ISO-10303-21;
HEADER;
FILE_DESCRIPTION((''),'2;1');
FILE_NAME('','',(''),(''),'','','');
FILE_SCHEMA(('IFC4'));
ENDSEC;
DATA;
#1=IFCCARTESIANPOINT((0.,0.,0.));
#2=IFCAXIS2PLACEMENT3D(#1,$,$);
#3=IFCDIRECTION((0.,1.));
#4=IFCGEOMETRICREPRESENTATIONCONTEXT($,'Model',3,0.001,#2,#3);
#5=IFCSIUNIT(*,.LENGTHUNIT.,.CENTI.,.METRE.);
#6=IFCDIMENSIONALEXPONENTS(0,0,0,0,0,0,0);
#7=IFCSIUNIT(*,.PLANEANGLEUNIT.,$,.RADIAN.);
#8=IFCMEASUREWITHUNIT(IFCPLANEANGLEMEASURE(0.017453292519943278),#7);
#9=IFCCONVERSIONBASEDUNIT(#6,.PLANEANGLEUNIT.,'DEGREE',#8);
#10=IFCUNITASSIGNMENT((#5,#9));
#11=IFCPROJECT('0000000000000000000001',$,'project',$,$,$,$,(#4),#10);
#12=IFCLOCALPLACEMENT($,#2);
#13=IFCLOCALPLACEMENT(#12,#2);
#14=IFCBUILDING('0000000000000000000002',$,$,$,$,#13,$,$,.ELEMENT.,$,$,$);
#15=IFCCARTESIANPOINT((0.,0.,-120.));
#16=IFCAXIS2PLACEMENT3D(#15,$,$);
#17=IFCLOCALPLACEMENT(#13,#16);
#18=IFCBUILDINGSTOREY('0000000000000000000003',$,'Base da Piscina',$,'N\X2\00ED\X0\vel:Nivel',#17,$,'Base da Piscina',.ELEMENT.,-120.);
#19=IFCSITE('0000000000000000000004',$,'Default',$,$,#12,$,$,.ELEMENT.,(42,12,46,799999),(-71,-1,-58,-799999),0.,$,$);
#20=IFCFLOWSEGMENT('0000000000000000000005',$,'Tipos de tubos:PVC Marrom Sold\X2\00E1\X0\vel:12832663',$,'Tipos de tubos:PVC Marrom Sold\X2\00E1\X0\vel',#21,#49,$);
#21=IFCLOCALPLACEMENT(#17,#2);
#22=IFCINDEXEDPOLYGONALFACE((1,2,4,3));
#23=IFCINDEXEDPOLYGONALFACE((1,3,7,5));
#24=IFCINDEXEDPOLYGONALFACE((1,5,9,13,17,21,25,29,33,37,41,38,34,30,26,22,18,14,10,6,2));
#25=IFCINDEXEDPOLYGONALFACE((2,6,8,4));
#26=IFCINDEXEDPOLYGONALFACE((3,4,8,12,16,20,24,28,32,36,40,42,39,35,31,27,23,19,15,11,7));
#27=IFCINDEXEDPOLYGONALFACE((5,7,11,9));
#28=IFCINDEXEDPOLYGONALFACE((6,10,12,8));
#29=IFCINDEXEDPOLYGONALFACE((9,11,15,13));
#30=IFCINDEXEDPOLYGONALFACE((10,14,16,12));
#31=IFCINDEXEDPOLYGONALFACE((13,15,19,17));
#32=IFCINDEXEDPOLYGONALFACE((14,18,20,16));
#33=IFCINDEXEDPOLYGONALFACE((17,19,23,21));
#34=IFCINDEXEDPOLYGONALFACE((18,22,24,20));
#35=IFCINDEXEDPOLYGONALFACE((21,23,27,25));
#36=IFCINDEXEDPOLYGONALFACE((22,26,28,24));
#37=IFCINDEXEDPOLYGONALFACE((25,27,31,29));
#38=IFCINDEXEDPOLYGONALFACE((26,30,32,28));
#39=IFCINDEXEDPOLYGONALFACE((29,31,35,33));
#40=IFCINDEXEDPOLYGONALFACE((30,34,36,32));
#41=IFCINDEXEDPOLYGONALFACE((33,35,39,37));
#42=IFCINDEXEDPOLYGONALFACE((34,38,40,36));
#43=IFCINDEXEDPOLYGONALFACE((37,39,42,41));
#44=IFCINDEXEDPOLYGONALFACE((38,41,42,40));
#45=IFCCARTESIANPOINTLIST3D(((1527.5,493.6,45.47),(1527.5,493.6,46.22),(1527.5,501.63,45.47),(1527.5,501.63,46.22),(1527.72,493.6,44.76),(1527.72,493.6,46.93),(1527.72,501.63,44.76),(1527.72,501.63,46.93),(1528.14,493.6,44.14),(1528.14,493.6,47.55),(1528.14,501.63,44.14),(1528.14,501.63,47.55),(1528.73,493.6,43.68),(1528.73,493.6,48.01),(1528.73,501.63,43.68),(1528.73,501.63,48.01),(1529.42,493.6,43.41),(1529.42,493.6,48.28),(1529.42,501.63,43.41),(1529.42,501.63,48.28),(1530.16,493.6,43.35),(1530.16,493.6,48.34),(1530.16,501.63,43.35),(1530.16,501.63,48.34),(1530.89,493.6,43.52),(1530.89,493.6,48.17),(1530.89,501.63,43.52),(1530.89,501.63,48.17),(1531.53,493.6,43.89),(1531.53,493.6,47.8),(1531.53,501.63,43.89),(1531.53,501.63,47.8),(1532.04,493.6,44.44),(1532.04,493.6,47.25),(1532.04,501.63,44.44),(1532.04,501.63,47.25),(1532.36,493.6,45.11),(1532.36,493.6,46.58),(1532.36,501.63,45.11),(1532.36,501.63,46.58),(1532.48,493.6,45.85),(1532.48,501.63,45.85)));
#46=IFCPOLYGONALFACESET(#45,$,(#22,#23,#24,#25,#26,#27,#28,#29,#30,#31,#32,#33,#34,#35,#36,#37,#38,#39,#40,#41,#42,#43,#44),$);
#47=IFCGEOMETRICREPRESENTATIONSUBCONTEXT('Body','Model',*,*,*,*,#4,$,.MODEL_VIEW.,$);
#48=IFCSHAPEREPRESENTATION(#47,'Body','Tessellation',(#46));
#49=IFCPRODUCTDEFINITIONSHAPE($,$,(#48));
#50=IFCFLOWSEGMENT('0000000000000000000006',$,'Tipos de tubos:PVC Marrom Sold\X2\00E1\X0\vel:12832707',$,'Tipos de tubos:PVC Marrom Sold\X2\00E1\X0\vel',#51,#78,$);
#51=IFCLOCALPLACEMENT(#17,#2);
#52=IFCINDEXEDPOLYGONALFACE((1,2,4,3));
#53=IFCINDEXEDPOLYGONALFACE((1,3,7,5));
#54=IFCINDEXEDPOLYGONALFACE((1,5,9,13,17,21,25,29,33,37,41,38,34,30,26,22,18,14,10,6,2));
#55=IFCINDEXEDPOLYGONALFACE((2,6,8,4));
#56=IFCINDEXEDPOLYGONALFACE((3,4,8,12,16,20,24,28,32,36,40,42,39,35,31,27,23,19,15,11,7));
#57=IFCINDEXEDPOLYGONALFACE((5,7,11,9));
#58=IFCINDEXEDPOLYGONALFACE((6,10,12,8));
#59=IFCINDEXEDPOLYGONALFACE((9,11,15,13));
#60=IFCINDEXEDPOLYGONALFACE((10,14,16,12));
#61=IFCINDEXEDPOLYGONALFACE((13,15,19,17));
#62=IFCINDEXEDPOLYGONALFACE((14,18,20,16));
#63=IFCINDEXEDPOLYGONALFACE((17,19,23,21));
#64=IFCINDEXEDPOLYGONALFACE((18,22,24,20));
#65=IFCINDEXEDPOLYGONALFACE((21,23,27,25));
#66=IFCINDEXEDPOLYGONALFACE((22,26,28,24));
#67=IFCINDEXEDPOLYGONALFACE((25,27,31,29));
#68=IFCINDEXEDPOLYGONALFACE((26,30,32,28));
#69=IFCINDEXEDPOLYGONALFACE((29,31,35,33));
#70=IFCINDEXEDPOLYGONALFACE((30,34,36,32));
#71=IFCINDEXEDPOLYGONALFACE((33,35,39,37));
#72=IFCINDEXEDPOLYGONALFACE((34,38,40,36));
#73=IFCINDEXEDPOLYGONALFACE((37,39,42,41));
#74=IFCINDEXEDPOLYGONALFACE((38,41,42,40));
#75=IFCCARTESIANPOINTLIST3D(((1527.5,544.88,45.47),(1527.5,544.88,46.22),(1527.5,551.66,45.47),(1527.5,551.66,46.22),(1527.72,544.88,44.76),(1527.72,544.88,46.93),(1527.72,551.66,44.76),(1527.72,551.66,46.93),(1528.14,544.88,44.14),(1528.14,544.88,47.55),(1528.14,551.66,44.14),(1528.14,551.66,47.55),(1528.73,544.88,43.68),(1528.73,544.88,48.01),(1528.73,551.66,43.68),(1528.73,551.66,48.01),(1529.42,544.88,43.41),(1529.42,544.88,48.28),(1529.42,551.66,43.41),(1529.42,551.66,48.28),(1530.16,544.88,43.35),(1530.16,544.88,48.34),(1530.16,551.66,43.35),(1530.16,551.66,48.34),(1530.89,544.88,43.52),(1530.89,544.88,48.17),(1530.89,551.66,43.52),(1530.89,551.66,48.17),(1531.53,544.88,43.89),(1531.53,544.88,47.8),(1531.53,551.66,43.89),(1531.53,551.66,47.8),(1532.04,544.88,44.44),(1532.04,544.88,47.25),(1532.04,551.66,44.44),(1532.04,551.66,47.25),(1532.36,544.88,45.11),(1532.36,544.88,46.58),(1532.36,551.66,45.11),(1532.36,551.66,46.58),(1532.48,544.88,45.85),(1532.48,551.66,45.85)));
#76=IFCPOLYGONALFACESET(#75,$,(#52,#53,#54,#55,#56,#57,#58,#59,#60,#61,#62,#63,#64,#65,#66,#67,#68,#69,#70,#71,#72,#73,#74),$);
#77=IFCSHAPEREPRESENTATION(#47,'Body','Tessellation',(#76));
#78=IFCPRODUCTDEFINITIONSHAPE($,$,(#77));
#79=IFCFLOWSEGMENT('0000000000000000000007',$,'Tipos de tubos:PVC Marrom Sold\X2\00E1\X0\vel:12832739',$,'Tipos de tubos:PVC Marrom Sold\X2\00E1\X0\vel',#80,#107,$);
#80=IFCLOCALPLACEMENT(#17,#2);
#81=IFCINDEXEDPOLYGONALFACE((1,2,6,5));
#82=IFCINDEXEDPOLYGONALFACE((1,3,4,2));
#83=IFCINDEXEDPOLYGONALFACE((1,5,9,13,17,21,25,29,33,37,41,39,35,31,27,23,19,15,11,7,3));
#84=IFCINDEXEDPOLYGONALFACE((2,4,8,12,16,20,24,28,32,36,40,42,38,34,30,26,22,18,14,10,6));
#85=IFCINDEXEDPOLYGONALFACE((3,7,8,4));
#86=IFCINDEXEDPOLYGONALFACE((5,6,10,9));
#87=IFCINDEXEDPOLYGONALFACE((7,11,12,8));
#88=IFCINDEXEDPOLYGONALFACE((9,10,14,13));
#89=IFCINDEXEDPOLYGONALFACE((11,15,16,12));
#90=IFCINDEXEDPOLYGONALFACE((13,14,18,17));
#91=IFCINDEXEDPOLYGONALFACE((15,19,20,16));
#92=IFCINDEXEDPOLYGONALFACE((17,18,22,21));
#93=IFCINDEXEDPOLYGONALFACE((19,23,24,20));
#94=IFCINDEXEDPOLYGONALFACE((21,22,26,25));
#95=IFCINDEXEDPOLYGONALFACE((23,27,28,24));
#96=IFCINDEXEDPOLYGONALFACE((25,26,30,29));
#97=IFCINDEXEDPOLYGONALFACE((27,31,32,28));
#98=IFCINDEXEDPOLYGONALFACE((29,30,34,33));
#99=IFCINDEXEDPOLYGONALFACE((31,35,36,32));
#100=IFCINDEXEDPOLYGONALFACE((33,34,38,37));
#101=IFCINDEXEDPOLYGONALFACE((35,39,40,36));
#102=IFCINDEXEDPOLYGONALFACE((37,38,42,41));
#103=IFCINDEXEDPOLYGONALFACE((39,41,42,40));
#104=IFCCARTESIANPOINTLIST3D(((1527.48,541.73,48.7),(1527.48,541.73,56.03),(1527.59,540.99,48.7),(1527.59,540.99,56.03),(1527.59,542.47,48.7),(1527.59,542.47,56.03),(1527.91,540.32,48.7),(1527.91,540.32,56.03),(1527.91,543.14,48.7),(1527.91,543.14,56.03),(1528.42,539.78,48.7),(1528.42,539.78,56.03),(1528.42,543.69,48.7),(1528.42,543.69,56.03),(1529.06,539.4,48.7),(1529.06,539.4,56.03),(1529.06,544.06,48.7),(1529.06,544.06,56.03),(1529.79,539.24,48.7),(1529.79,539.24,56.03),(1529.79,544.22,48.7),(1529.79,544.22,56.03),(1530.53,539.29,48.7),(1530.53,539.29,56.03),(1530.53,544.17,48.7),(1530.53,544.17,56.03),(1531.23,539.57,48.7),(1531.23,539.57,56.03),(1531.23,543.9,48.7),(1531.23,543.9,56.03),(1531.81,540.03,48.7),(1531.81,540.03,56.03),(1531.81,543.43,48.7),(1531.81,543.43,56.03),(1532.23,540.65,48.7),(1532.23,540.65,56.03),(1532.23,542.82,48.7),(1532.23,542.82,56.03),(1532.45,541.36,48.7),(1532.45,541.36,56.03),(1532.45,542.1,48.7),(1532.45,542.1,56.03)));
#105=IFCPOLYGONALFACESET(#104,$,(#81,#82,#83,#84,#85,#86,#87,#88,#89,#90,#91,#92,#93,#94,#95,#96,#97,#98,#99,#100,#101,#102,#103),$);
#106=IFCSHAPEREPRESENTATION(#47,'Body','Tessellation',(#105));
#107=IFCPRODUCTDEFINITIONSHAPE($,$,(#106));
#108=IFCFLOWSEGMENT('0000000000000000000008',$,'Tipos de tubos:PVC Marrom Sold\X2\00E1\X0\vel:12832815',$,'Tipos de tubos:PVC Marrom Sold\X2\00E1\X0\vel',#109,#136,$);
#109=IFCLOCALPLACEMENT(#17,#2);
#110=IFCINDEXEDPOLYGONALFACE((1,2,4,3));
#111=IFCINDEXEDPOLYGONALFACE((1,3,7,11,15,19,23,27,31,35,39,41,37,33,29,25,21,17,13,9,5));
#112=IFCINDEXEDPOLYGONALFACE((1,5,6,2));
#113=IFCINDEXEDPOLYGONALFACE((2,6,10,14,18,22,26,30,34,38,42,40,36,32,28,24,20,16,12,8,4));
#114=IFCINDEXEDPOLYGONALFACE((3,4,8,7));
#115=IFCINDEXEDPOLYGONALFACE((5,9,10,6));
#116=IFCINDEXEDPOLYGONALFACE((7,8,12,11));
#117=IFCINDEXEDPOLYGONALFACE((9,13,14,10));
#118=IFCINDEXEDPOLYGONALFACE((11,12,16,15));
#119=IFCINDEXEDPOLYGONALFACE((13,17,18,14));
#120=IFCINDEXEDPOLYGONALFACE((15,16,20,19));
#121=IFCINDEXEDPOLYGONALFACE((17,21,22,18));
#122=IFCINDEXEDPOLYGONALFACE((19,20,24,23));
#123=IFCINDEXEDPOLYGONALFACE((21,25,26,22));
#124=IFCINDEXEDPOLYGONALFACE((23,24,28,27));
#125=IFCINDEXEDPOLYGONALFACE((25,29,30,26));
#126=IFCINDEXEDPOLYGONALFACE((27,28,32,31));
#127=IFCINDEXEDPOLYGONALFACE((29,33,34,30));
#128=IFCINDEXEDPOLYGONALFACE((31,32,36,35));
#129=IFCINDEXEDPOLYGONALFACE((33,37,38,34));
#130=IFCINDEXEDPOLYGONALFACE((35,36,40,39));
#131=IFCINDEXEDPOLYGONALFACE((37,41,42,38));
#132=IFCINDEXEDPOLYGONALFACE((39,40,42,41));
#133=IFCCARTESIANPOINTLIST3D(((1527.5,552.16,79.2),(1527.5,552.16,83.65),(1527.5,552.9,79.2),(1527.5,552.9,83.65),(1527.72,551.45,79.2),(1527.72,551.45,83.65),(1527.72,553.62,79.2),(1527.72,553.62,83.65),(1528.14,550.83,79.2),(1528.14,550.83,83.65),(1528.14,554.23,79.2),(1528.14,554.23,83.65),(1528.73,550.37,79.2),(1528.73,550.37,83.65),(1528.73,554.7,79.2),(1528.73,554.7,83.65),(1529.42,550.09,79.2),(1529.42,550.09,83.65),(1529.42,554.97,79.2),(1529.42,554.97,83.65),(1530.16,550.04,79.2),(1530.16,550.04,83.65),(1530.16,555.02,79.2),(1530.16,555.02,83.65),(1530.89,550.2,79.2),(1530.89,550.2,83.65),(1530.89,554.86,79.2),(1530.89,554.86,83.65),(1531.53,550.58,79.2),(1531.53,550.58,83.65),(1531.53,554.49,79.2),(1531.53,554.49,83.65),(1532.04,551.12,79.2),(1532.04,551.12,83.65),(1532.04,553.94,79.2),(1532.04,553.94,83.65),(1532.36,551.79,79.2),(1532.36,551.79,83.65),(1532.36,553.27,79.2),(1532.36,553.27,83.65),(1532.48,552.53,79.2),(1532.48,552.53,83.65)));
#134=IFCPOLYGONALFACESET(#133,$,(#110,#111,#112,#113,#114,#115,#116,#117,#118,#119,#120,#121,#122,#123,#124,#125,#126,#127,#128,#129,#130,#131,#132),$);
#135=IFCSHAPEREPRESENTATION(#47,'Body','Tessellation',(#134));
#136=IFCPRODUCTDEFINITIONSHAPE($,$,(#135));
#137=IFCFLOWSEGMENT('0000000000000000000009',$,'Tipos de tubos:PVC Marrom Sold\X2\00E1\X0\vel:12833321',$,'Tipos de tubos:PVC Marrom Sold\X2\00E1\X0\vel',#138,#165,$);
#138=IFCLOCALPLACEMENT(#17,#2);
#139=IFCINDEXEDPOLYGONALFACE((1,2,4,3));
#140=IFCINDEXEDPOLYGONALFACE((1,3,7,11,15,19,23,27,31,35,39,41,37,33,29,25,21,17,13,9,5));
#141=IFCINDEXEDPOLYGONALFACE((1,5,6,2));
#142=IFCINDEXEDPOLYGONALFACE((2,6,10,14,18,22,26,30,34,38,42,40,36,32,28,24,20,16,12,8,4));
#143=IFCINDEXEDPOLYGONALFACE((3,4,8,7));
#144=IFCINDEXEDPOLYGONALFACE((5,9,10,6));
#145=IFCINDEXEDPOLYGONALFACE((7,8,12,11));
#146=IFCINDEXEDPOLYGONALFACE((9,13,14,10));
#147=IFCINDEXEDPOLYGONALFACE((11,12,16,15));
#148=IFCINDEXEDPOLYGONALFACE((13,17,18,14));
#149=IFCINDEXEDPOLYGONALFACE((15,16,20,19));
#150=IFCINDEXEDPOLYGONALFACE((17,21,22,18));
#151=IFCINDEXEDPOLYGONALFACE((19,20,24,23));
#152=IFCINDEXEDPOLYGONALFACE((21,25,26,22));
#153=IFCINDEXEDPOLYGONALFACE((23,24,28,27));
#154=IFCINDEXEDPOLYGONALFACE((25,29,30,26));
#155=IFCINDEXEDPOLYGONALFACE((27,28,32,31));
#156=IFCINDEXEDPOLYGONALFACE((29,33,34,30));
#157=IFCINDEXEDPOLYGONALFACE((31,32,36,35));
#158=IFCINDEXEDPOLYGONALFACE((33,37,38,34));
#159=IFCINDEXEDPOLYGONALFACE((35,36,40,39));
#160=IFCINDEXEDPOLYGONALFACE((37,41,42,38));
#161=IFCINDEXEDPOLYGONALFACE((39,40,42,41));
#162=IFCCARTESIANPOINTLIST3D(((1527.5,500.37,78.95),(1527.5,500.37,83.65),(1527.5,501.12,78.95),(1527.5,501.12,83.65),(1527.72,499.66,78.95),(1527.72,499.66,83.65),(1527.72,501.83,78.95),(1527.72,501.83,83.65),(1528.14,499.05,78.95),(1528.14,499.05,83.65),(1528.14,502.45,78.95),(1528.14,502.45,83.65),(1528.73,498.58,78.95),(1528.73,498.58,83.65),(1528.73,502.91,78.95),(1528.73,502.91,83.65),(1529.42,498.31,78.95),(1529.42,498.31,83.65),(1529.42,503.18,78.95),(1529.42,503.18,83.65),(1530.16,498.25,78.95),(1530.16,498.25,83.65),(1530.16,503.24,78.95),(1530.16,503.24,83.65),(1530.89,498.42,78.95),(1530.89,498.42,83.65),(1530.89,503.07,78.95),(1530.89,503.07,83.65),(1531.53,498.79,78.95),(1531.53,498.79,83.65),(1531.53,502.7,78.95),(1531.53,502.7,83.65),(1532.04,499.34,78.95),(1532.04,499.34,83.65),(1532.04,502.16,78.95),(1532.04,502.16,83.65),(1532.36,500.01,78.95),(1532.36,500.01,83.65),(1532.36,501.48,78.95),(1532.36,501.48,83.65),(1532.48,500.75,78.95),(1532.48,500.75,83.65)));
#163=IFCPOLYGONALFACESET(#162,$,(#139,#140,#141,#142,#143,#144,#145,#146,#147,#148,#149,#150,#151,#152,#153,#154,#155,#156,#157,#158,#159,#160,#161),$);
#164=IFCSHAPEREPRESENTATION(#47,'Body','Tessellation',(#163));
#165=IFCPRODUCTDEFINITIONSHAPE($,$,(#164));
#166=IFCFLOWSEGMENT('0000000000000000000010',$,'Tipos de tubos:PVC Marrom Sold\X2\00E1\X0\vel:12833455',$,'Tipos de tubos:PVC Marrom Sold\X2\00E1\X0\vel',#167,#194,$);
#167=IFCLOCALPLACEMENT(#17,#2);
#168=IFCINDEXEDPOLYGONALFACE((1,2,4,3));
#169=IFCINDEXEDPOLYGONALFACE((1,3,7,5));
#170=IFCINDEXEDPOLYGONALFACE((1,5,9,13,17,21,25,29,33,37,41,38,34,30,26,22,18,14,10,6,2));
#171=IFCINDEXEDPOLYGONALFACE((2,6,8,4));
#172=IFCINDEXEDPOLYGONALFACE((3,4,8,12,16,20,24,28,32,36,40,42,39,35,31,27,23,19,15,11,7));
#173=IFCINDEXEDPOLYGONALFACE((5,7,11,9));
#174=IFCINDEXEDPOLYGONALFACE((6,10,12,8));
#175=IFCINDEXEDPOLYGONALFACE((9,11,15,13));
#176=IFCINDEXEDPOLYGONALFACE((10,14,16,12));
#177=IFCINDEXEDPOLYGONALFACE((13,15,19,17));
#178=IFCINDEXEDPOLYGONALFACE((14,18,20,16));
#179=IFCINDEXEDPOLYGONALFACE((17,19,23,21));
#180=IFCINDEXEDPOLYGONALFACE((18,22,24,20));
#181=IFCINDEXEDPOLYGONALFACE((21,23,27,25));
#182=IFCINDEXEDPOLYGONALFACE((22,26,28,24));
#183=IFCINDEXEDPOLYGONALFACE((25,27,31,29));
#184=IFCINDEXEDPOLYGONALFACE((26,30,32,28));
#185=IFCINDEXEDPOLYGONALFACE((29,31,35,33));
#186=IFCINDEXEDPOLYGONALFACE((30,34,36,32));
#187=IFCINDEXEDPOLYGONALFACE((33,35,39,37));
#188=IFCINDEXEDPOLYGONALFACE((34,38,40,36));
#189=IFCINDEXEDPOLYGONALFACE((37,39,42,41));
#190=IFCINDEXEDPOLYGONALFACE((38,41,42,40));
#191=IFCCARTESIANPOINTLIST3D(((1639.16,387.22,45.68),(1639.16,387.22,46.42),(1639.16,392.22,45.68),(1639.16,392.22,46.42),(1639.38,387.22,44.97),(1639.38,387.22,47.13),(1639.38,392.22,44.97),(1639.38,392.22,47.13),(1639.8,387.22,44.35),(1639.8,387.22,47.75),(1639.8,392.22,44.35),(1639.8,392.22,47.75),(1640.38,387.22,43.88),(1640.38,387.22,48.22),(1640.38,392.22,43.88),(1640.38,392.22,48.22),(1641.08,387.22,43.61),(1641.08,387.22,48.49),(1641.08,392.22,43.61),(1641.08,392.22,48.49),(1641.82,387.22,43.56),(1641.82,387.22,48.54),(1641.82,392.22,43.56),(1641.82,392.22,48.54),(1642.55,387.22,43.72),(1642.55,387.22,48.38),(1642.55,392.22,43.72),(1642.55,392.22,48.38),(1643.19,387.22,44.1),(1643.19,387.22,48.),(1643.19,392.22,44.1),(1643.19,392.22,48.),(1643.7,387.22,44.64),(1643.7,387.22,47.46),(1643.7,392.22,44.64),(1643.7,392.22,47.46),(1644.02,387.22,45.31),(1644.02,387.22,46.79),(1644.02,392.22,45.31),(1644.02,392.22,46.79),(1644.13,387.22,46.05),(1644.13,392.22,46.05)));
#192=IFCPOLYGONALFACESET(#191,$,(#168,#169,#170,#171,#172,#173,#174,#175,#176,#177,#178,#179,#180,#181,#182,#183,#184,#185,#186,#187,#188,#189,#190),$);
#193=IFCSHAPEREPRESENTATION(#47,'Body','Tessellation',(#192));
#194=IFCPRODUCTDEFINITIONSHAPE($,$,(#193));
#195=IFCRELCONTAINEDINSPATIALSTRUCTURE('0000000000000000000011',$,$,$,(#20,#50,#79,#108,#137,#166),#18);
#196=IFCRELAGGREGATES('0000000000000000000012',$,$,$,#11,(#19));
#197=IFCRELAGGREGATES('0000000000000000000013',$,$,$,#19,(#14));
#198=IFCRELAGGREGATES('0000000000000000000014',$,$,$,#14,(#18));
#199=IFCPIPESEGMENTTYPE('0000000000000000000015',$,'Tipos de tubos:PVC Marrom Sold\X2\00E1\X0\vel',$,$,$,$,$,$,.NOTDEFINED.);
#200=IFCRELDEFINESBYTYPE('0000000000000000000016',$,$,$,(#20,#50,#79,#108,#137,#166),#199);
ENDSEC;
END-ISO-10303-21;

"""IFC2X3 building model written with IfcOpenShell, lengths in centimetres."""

from ifc_helpers import new_model, entity, si_unit, converted_unit, direction, frame, frame_2d, origin, origin_2d_with_axis, place, context, subcontext, project, spatial, circle, extrude, type_object, element, save


model = new_model("IFC2X3")

# Units and contexts
model_context = context("Model", 3, precision=0.001, world=origin(), true_north=direction((0.0, 1.0)))
body_context = subcontext(model_context, "Body", "Model", "MODEL_VIEW")
ifc_project = project(units=[si_unit("LENGTHUNIT", "METRE", prefix="CENTI"), converted_unit("PLANEANGLEUNIT", "DEGREE", entity("IfcPlaneAngleMeasure", 0.017453292519943278), si_unit("PLANEANGLEUNIT", "RADIAN"), dimensions=[0, 0, 0, 0, 0, 0, 0])], contexts=[model_context])

# Site, building, storey
site_placement = place(None, origin())
site = spatial("IfcSite", under=ifc_project, at=site_placement, Name="Default", CompositionType="ELEMENT", RefLatitude=(42, 12, 46, 799999), RefLongitude=(-71, -1, -58, -799999), RefElevation=0.0)
building_placement = place(site_placement, origin())
building = spatial("IfcBuilding", under=site, at=building_placement, CompositionType="ELEMENT")
storey_placement = place(building_placement, frame((0.0, 0.0, -120.0)))
storey = spatial("IfcBuildingStorey", under=building, at=storey_placement, Name="Base da Piscina", ObjectType="Nível:Nivel", LongName="Base da Piscina", CompositionType="ELEMENT", Elevation=-120.0)

# Flow segments
pipe_segment_type = type_object("IfcPipeSegmentType", Name="Tipos de tubos:PVC Marrom Soldável", PredefinedType="NOTDEFINED")
flow_segment_1_placement = place(storey_placement, origin())
element("IfcFlowSegment", 1, at=flow_segment_1_placement, inside=storey, type_object=pipe_segment_type, Name="Tipos de tubos:PVC Marrom Soldável:12832663", ObjectType="Tipos de tubos:PVC Marrom Soldável", context=body_context, shape_type="SweptSolid", body=[
    extrude(circle(Radius=2.5, at=origin_2d_with_axis()), frame((1529.98, 493.6, 45.85), z_axis=(0.0, 1.0, 0.0), x_axis=(1.0, 0.0, 0.0)), (0.0, 0.0, 1.0), 8.03),
])
flow_segment_2_placement = place(storey_placement, origin())
element("IfcFlowSegment", 2, at=flow_segment_2_placement, inside=storey, type_object=pipe_segment_type, Name="Tipos de tubos:PVC Marrom Soldável:12832707", ObjectType="Tipos de tubos:PVC Marrom Soldável", context=body_context, shape_type="SweptSolid", body=[
    extrude(circle(Radius=2.5, at=origin_2d_with_axis()), frame((1529.98, 544.88, 45.85), z_axis=(0.0, 1.0, 0.0), x_axis=(1.0, 0.0, 0.0)), (0.0, 0.0, 1.0), 6.78),
])
flow_segment_3_placement = place(storey_placement, origin())
element("IfcFlowSegment", 3, at=flow_segment_3_placement, inside=storey, type_object=pipe_segment_type, Name="Tipos de tubos:PVC Marrom Soldável:12832739", ObjectType="Tipos de tubos:PVC Marrom Soldável", context=body_context, shape_type="SweptSolid", body=[
    extrude(circle(Radius=2.5, at=origin_2d_with_axis()), frame((1529.98, 541.73, 48.7), z_axis=(0.0, 0.0, 1.0), x_axis=(-1.0, 0.0, 0.0)), (0.0, 0.0, 1.0), 7.34),
])
flow_segment_4_placement = place(storey_placement, origin())
element("IfcFlowSegment", 4, at=flow_segment_4_placement, inside=storey, type_object=pipe_segment_type, Name="Tipos de tubos:PVC Marrom Soldável:12832815", ObjectType="Tipos de tubos:PVC Marrom Soldável", context=body_context, shape_type="SweptSolid", body=[
    extrude(circle(Radius=2.5, at=origin_2d_with_axis()), frame((1529.98, 552.53, 79.2)), (0.0, 0.0, 1.0), 4.45),
])
flow_segment_5_placement = place(storey_placement, origin())
element("IfcFlowSegment", 5, at=flow_segment_5_placement, inside=storey, type_object=pipe_segment_type, Name="Tipos de tubos:PVC Marrom Soldável:12833321", ObjectType="Tipos de tubos:PVC Marrom Soldável", context=body_context, shape_type="SweptSolid", body=[
    extrude(circle(Radius=2.5, at=frame_2d((0.0, 0.0), x_axis=(1.0, 0.0))), frame((1529.98, 500.75, 78.95)), (0.0, 0.0, 1.0), 4.7),
])
flow_segment_6_placement = place(storey_placement, origin())
element("IfcFlowSegment", 6, at=flow_segment_6_placement, inside=storey, type_object=pipe_segment_type, Name="Tipos de tubos:PVC Marrom Soldável:12833455", ObjectType="Tipos de tubos:PVC Marrom Soldável", context=body_context, shape_type="SweptSolid", body=[
    extrude(circle(Radius=2.5, at=origin_2d_with_axis()), frame((1641.63, 387.22, 46.05), z_axis=(0.0, 1.0, 0.0), x_axis=(1.0, 0.0, 0.0)), (0.0, 0.0, 1.0), 5.0),
])

save(model, "model.ifc")
